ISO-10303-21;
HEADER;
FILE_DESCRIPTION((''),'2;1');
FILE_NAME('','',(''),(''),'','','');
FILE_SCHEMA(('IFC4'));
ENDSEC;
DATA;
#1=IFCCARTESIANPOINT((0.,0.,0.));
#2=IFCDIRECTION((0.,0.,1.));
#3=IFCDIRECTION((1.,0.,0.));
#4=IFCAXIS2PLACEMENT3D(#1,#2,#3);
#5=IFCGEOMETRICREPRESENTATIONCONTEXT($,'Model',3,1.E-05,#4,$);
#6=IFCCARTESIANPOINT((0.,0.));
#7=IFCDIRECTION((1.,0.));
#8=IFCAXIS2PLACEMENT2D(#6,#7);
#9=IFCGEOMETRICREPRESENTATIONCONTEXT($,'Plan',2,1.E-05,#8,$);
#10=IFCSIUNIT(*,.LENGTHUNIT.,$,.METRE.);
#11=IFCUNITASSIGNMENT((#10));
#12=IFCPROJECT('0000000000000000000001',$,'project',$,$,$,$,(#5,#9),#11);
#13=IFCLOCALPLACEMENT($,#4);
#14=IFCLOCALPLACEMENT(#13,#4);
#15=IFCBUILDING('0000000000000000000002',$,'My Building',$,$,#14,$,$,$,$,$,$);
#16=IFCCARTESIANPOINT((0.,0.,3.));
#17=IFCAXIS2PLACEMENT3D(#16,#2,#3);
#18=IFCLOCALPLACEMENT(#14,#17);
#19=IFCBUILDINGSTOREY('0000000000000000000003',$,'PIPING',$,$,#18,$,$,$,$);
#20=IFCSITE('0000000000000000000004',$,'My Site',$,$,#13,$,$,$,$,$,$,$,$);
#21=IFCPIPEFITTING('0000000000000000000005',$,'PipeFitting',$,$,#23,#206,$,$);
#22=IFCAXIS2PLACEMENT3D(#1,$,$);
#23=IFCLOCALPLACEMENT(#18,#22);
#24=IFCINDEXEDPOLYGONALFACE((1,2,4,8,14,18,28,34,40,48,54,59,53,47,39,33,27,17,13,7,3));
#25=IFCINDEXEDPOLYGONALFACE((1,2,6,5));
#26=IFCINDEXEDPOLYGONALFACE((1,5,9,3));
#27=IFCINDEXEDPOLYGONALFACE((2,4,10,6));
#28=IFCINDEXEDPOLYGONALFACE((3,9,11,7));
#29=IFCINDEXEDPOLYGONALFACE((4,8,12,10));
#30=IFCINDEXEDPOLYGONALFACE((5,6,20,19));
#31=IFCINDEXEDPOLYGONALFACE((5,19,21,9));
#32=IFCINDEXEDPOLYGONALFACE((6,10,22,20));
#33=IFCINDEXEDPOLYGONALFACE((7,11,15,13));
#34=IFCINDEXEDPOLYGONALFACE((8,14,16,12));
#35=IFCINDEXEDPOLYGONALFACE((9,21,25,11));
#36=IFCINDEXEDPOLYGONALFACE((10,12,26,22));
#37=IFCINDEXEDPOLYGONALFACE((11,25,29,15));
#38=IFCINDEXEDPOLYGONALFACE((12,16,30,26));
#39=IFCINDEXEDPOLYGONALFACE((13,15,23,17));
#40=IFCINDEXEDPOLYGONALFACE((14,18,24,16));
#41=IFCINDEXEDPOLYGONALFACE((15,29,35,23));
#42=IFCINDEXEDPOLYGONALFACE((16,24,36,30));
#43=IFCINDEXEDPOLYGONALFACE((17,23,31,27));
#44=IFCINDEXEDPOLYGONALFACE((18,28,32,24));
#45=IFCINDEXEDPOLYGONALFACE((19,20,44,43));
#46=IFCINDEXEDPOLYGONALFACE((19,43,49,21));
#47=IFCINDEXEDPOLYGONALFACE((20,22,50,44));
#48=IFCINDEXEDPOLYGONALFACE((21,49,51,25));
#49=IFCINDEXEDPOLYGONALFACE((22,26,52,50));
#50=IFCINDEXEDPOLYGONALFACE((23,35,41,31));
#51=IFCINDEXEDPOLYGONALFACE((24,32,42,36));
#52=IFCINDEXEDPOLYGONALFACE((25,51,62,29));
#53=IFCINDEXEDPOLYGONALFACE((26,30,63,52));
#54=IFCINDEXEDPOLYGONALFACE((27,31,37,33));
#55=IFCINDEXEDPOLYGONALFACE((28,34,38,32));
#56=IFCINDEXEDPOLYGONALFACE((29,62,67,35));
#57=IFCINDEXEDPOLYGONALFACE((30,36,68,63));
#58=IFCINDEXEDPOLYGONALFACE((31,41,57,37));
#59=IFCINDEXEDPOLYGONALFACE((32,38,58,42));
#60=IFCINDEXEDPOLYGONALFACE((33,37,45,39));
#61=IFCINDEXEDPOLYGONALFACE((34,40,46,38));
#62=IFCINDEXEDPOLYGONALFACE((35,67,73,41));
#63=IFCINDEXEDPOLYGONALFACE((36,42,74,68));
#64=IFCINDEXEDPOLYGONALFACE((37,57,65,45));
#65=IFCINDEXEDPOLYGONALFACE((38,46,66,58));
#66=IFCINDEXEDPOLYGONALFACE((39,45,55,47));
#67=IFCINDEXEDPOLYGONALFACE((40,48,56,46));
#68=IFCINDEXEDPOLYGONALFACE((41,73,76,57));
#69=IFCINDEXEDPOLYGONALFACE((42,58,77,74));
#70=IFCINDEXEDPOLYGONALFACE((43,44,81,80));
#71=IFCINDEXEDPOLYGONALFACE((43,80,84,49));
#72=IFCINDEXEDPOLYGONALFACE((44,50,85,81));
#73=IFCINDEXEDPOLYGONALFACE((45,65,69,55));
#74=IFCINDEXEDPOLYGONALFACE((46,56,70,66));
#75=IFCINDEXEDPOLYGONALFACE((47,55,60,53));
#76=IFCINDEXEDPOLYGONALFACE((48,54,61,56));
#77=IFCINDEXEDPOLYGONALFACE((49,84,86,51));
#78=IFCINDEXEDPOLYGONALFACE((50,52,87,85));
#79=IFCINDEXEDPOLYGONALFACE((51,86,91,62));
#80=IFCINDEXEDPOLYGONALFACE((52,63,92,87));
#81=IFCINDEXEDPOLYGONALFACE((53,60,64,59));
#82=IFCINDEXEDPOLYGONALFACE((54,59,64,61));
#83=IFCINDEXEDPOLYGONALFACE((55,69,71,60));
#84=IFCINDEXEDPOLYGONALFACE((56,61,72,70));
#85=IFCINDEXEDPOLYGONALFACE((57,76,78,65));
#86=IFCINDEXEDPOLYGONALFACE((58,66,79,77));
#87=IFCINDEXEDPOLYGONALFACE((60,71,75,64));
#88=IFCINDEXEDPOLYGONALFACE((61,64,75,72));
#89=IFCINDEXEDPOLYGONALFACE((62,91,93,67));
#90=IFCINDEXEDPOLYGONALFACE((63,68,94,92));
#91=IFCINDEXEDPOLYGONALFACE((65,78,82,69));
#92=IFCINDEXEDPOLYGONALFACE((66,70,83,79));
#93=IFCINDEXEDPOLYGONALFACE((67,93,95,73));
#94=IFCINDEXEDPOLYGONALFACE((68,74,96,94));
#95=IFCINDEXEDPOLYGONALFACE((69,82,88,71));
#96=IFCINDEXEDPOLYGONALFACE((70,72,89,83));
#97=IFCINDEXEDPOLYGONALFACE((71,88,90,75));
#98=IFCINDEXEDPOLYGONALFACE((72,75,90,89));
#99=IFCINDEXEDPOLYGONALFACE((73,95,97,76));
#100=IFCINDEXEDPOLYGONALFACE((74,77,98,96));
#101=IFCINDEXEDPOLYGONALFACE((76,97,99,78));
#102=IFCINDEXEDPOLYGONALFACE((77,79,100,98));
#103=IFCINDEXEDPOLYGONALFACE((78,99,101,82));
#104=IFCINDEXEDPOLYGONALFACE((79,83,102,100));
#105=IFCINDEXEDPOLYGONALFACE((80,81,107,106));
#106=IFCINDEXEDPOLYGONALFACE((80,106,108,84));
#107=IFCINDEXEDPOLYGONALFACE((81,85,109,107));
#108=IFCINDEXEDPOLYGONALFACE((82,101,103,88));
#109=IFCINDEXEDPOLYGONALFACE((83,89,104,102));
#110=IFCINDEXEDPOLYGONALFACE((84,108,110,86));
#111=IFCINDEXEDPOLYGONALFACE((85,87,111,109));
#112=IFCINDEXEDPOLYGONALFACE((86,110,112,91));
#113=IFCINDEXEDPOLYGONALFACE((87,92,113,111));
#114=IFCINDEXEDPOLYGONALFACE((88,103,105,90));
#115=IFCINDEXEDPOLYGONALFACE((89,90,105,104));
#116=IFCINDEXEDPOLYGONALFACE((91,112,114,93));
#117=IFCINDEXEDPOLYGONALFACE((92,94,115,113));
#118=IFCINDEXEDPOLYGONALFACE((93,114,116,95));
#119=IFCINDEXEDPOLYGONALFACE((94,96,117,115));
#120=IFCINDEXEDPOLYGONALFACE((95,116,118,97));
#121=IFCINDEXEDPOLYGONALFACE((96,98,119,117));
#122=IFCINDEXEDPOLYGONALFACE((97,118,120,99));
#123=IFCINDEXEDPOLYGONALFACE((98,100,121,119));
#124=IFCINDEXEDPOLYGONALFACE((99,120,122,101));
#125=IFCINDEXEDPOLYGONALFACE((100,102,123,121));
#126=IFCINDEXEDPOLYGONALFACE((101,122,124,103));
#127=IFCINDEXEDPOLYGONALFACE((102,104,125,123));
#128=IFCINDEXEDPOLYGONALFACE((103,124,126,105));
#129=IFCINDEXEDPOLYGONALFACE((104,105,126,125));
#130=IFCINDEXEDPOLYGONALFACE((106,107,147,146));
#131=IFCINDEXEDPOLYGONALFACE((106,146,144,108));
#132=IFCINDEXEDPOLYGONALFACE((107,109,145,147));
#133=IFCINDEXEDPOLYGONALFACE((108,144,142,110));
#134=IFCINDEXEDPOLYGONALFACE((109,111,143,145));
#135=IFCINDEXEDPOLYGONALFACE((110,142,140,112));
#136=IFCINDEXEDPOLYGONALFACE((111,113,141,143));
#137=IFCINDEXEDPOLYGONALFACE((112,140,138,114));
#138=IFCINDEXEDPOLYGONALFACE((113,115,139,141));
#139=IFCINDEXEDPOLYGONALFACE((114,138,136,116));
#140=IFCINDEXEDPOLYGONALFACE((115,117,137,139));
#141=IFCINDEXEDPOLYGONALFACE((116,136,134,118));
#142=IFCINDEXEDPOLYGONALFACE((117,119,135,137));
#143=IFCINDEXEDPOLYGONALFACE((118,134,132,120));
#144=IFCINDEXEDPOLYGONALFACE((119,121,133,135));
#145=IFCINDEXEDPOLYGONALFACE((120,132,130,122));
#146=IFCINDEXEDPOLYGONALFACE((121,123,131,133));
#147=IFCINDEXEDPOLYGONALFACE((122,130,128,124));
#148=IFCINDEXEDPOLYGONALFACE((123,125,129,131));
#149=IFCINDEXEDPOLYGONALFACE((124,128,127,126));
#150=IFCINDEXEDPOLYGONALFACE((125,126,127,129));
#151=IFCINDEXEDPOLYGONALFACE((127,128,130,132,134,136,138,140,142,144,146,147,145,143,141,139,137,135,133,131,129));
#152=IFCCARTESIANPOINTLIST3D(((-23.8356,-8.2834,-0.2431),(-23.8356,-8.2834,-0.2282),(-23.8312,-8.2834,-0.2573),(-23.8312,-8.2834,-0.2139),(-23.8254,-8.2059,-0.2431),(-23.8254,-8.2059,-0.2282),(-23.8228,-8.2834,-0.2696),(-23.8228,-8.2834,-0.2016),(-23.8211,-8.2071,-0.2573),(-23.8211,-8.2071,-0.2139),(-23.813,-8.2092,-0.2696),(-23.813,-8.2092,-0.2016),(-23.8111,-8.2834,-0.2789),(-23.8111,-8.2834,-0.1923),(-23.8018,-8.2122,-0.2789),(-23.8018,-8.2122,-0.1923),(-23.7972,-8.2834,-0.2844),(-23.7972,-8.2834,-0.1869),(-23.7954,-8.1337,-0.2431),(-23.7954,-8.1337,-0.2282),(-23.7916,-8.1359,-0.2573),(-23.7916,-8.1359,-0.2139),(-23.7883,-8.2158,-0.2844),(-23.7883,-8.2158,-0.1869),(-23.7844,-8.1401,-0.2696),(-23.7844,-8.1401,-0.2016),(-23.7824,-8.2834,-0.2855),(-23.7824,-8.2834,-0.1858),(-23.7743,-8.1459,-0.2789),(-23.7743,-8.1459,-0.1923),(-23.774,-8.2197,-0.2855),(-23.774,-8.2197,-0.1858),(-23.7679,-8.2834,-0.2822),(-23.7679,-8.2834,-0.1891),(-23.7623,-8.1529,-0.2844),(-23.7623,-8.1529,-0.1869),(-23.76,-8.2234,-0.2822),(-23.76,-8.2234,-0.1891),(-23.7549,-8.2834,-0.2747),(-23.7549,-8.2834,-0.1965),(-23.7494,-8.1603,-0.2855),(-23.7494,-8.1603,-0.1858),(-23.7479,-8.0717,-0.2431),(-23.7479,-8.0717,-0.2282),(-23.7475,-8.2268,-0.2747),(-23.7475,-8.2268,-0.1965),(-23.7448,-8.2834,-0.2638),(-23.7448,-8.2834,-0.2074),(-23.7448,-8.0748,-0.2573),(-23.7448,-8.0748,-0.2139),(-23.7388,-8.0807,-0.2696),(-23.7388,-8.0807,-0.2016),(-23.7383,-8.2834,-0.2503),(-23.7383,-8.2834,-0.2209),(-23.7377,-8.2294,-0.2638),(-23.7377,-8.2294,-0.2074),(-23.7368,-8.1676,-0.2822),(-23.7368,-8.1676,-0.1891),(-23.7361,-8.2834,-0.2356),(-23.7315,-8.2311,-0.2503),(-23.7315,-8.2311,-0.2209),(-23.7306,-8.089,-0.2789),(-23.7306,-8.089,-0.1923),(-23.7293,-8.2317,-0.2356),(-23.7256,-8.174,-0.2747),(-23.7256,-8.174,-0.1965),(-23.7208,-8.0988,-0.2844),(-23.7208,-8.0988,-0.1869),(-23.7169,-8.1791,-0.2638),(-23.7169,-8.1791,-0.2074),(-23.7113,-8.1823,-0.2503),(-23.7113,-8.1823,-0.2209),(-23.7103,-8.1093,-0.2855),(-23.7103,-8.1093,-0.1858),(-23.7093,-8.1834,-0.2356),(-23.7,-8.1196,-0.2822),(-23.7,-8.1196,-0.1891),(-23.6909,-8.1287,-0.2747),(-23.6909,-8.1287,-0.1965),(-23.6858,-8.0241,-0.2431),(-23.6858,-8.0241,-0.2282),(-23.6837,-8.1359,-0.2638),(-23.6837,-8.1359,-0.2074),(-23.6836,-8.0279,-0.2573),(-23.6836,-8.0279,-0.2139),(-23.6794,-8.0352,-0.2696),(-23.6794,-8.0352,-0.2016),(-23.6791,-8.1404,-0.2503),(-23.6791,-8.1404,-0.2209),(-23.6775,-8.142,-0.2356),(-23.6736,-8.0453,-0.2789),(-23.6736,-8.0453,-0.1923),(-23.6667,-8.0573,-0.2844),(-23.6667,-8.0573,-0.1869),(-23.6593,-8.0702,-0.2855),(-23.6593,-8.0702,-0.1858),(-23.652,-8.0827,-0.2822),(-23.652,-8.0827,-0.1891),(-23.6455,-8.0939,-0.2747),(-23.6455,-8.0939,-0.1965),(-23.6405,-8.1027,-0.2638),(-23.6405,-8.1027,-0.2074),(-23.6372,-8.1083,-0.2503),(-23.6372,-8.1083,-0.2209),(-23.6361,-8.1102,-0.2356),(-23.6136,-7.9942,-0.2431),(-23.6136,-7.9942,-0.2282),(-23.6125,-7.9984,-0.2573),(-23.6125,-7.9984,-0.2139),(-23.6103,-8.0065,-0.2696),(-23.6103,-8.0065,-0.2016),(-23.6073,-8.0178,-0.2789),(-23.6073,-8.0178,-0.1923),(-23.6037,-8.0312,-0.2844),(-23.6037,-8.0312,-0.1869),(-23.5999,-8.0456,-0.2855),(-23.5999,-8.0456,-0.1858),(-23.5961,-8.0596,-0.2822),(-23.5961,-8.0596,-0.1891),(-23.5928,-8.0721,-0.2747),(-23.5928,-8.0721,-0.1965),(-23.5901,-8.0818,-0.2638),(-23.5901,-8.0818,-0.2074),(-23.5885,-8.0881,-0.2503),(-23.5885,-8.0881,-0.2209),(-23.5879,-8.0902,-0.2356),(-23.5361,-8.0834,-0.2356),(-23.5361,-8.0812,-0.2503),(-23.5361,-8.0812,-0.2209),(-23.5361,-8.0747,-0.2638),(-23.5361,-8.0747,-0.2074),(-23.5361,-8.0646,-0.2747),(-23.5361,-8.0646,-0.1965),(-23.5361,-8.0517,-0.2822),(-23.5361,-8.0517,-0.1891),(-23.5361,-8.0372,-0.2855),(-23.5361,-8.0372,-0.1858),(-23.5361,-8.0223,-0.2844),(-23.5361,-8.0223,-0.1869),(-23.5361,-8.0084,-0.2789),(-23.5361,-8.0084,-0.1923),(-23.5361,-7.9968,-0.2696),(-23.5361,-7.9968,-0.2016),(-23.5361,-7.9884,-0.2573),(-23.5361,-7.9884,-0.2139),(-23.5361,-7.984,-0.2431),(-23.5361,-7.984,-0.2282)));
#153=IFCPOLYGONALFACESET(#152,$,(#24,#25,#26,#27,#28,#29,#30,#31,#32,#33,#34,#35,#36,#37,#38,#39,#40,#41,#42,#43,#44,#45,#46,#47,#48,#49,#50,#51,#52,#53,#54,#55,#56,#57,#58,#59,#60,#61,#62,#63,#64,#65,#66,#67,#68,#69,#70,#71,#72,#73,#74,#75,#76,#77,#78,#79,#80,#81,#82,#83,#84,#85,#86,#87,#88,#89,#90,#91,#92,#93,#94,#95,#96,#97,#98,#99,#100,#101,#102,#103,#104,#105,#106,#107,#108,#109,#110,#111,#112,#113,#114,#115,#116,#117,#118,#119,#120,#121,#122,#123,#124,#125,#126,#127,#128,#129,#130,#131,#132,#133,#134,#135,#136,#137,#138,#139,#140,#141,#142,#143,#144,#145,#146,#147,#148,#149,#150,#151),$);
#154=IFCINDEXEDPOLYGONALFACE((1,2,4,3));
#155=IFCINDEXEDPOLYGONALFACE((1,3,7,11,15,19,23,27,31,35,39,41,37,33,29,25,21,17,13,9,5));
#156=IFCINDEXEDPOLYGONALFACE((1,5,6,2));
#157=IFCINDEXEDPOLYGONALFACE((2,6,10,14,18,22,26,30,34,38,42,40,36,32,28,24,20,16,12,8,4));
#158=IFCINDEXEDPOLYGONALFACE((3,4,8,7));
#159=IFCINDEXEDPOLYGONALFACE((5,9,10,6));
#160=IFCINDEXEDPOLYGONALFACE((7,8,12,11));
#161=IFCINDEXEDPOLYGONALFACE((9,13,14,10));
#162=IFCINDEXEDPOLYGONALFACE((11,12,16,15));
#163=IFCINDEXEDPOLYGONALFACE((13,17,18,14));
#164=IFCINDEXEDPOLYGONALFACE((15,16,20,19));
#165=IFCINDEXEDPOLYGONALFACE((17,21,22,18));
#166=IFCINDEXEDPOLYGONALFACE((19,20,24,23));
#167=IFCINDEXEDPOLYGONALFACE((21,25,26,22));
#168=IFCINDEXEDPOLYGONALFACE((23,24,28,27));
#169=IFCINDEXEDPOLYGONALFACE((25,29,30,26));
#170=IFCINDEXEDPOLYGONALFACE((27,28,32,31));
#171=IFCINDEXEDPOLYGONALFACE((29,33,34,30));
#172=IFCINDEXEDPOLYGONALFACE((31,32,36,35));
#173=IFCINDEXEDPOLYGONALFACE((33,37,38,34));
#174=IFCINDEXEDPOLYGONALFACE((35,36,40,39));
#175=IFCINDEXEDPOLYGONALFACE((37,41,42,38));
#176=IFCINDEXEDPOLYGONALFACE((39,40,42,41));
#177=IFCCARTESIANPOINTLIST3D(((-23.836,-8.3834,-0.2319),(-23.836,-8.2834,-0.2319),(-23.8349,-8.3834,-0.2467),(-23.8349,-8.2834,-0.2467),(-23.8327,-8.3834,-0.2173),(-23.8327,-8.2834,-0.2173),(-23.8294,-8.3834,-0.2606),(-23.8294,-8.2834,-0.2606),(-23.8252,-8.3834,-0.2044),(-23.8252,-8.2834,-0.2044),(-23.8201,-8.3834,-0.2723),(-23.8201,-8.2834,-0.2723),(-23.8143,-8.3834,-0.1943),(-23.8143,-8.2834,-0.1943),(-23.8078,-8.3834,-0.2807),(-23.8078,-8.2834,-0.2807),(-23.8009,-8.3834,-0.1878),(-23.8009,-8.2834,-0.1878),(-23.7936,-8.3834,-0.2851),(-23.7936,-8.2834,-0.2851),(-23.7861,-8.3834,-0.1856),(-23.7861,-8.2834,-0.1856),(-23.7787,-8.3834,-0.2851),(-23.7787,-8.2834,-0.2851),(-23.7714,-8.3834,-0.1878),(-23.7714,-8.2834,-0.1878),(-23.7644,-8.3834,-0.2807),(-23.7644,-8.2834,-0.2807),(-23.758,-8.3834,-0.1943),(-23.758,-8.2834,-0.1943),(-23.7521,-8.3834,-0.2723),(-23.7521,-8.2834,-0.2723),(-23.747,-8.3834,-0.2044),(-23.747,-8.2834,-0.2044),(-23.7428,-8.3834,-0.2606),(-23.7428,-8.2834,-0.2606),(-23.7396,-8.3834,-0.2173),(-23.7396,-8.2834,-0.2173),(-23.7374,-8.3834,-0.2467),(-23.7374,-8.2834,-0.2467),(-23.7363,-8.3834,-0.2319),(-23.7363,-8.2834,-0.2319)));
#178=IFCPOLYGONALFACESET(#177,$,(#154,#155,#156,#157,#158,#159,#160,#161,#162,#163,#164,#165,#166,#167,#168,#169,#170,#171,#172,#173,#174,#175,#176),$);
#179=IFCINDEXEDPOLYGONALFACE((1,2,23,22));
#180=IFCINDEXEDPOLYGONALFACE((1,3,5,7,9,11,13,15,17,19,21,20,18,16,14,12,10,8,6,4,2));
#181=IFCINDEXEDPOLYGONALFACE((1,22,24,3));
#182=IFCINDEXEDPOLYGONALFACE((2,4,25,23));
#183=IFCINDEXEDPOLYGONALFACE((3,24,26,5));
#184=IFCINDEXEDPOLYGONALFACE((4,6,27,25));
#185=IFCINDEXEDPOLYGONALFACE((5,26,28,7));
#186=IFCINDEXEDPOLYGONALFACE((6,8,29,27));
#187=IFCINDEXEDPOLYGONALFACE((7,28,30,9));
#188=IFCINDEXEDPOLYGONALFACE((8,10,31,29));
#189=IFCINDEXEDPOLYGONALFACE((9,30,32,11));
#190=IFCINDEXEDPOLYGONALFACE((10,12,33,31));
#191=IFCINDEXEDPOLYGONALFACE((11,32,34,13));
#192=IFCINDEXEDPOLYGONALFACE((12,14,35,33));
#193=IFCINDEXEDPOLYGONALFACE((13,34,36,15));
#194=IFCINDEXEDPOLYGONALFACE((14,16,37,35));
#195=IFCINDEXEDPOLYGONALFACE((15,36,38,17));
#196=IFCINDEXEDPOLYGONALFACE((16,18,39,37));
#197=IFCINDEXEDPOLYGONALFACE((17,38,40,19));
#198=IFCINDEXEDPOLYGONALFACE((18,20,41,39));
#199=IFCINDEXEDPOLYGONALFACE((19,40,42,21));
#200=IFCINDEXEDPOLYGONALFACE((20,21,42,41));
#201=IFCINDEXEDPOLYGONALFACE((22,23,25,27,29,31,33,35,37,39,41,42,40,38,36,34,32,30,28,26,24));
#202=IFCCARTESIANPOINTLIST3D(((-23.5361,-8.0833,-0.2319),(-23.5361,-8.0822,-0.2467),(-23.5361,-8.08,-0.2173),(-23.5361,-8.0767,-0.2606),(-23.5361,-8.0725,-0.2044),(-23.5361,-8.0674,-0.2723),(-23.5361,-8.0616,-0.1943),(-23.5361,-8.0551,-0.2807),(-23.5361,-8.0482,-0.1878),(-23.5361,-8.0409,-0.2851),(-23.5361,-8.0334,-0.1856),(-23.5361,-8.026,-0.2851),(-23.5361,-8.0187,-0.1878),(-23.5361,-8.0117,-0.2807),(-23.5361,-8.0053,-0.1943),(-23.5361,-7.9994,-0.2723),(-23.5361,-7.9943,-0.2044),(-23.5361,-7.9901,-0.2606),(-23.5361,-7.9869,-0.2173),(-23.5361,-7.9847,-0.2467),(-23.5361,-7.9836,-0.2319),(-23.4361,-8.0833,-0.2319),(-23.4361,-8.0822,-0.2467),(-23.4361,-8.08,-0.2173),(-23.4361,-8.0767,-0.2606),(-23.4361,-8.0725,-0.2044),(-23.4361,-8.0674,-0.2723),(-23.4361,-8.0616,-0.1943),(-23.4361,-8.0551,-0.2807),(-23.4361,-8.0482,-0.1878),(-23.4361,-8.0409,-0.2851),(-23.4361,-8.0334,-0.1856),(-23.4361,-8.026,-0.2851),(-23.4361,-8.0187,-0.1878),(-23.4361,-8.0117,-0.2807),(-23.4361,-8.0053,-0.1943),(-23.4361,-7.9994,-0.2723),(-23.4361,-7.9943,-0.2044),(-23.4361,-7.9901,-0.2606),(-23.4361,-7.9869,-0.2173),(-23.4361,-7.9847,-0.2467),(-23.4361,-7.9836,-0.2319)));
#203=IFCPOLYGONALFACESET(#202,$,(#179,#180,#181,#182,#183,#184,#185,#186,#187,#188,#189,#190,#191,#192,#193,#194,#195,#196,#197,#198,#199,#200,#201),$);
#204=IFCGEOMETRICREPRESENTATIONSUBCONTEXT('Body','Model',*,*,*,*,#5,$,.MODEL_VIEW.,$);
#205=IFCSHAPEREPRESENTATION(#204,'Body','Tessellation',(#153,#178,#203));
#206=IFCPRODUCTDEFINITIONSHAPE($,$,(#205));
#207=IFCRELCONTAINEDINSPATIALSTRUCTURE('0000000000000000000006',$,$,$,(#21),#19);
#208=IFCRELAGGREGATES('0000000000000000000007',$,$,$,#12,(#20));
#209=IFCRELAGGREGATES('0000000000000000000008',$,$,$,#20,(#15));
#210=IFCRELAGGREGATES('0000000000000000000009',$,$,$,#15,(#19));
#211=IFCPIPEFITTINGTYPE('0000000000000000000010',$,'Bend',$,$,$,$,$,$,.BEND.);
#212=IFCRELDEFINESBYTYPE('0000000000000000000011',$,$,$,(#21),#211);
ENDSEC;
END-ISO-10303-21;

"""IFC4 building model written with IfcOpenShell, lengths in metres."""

from ifc_helpers import new_model, entity, si_unit, frame, origin_with_axes, origin_2d_with_axis, place, context, subcontext, project, spatial, circle, extrude, source, transform, mapped, type_object, type_shapes, element, save


model = new_model("IFC4")

# Units and contexts
model_context = context("Model", 3, precision=1e-05, world=origin_with_axes())
plan_context = context("Plan", 2, precision=1e-05, world=origin_2d_with_axis())
body_context = subcontext(model_context, "Body", "Model", "MODEL_VIEW")
ifc_project = project(units=[si_unit("LENGTHUNIT", "METRE")], contexts=[model_context, plan_context])

# Site, building, storey
site_placement = place(None, origin_with_axes())
site = spatial("IfcSite", under=ifc_project, at=site_placement, Name="My Site")
building_placement = place(site_placement, origin_with_axes())
building = spatial("IfcBuilding", under=site, at=building_placement, Name="My Building")
storey_placement = place(building_placement, frame((0.0, 0.0, 3.0), z_axis=(0.0, 0.0, 1.0), x_axis=(1.0, 0.0, 0.0)))
storey = spatial("IfcBuildingStorey", under=building, at=storey_placement, Name="PIPING")

# Pipe fitting
pipe_fitting_type = type_object("IfcPipeFittingType", Name="Bend", PredefinedType="BEND")
shared_shape = source(origin_with_axes(), body_context, "Body", "SolidModel", [
    entity("IfcSweptDiskSolid", entity("IfcIndexedPolyCurve", entity("IfcCartesianPointList3D", [[0.0, 0.0, -0.1], [0.0, -0.0732, -0.2768], [0.0, -0.25, -0.35]]), [entity("IfcArcIndex", [1, 2, 3])]), 0.05),
    extrude(circle(Radius=0.05), origin_with_axes(), (0.0, 0.0, -1.0), 0.1),
    extrude(circle(Radius=0.05), frame((0.0, -0.25, -0.35), z_axis=(0.0, -1.0, 0.0), x_axis=(1.0, 0.0, 0.0)), (0.0, 0.0, 1.0), 0.1),
])
type_shapes(pipe_fitting_type, [shared_shape])
for number, where, z_axis, x_axis, name in (
    (1, (-23.7861, -8.3834, -0.2356), (0.0, -1.0, 0.0), (0.0, 0.0, 1.0), "PipeFitting"),
):
    element("IfcPipeFitting", number, at=place(storey_placement, frame(where, z_axis=z_axis, x_axis=x_axis)), inside=storey, type_object=pipe_fitting_type, Name=name, context=body_context, shape_type="MappedRepresentation", body=[
        mapped(shared_shape, transform((0.0, 0.0, 0.0), x_axis=(1.0, 0.0, 0.0), y_axis=(0.0, 1.0, 0.0), z_axis=(0.0, 0.0, 1.0), scale=1.0)),
    ])

save(model, "model.ifc")
